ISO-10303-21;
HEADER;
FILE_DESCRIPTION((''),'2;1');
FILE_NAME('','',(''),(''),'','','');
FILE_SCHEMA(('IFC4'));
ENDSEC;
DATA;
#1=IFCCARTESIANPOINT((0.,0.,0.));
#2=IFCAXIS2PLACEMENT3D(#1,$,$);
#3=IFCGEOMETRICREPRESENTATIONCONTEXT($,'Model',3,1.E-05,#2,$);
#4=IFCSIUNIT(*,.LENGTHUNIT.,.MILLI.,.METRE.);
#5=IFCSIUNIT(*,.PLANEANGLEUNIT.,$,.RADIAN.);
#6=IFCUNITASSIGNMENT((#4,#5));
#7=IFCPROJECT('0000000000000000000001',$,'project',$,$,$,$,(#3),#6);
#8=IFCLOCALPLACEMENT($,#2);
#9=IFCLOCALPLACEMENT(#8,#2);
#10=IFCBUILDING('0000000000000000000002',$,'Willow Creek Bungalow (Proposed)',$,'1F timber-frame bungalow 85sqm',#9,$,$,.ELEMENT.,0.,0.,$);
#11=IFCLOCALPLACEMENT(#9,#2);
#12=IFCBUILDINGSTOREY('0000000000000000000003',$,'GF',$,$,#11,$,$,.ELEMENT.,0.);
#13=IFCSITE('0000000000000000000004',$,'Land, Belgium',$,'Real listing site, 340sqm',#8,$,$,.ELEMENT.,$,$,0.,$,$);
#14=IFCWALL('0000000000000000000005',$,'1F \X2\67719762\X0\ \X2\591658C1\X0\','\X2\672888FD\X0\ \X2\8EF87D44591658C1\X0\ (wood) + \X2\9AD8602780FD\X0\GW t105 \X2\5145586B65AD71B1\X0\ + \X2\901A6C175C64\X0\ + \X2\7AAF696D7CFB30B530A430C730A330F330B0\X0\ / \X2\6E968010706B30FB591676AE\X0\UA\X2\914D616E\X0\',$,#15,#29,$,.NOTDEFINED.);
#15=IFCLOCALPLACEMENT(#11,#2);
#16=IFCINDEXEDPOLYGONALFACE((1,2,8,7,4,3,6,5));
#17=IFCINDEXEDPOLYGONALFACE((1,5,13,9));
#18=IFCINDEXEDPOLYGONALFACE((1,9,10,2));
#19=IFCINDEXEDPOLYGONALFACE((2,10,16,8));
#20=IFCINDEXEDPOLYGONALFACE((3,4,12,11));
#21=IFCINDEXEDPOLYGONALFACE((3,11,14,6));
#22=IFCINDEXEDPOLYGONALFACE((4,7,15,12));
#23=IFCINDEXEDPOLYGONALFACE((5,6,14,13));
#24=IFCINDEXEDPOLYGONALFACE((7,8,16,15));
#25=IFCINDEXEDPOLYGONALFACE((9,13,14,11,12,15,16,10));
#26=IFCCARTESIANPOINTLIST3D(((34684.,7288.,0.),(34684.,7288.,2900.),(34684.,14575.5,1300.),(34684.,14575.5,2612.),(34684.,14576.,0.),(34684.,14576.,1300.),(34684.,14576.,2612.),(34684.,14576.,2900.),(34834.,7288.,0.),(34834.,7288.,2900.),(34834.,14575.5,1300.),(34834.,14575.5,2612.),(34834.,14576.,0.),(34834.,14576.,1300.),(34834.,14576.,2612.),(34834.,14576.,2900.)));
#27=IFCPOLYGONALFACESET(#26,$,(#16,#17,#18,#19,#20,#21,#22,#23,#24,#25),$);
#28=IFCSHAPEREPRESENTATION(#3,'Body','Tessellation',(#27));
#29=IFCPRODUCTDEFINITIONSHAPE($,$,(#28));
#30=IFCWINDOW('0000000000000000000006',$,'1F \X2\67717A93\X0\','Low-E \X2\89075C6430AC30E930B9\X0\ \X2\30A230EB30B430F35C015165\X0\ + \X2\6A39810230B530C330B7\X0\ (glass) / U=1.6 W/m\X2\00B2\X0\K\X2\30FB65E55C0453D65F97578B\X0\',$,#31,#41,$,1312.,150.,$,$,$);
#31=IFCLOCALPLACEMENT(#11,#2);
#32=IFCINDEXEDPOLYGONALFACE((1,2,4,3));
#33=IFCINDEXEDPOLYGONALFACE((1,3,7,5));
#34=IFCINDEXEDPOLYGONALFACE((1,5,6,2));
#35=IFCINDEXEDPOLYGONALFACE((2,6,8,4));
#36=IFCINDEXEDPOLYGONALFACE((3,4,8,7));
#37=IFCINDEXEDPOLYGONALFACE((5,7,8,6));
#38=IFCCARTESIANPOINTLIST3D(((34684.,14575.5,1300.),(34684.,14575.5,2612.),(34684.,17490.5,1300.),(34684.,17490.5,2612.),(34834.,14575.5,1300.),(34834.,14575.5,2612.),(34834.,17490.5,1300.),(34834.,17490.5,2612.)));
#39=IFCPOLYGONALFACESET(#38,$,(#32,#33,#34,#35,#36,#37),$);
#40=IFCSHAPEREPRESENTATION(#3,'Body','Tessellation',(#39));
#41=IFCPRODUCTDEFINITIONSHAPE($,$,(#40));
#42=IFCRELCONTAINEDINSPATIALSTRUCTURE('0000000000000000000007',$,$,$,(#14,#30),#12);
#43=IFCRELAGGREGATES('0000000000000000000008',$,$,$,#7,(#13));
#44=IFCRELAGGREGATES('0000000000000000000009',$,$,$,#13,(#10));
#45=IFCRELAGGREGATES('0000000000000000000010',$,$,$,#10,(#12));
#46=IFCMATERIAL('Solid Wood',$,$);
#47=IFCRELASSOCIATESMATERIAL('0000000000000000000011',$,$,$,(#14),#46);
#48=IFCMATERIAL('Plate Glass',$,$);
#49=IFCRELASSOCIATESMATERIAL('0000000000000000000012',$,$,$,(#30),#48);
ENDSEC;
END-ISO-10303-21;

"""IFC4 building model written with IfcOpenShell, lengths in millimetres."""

from ifc_helpers import new_model, si_unit, frame, frame_2d, origin, place, context, project, spatial, rectangle, extrude, material, element, fill, save


model = new_model("IFC4")

# Units and contexts
model_context = context("Model", 3, precision=1e-05, world=origin())
ifc_project = project(units=[si_unit("LENGTHUNIT", "METRE", prefix="MILLI"), si_unit("PLANEANGLEUNIT", "RADIAN")], contexts=[model_context])

# Site, building, storey
site_placement = place(None, origin())
site = spatial("IfcSite", under=ifc_project, at=site_placement, Name="Land, Belgium", ObjectType="Real listing site, 340sqm", CompositionType="ELEMENT", RefElevation=0.0)
building_placement = place(site_placement, origin())
building = spatial("IfcBuilding", under=site, at=building_placement, Name="Willow Creek Bungalow (Proposed)", ObjectType="1F timber-frame bungalow 85sqm", CompositionType="ELEMENT", ElevationOfRefHeight=0.0, ElevationOfTerrain=0.0)
storey_placement = place(building_placement, origin())
storey = spatial("IfcBuildingStorey", under=building, at=storey_placement, Name="GF", CompositionType="ELEMENT", Elevation=0.0)

# Shared definitions
ifc_material_1 = material(Name="Solid Wood")

# Wall, opening, window
wall_1_placement = place(storey_placement, frame((17342.0, 3644.0, 0.0)))
wall_1 = element("IfcWall", 1, at=wall_1_placement, inside=storey, material=ifc_material_1, Name="1F 東面 外壁", Description="木製 軸組外壁 (wood) + 高性能GW t105 充填断熱 + 通気層 + 窯業系サイディング / 準耐火・外皮UA配慮", PredefinedType="NOTDEFINED", context=model_context, shape_type="SweptSolid", body=[
    extrude(rectangle(XDim=150.0, YDim=7288.0, at=frame_2d((75.0, 3644.0))), frame((17342.0, 3644.0, 0.0)), (0.0, 0.0, 1.0), 2900.0),
])
opening_placement = place(storey_placement, frame((17342.0, 7288.0, 650.0)))
opening = element("IfcOpeningElement", 2, at=opening_placement, cuts=wall_1, PredefinedType="NOTDEFINED", context=model_context, shape_type="SweptSolid", body=[
    extrude(rectangle(XDim=150.0, YDim=2915.0, at=frame_2d((75.0, 1457.0))), frame((17342.0, 7288.0, 650.0)), (0.0, 0.0, 1.0), 1312.0),
])
ifc_material_2 = material(Name="Plate Glass")
window_placement = place(storey_placement, frame((17342.0, 7288.0, 650.0)))
window = element("IfcWindow", 3, at=window_placement, inside=storey, material=ifc_material_2, Name="1F 東窓", Description="Low-E 複層ガラス アルゴン封入 + 樹脂サッシ (glass) / U=1.6 W/m²K・日射取得型", OverallHeight=1312.0, OverallWidth=150.0, context=model_context, shape_type="SweptSolid", body=[
    extrude(rectangle(XDim=150.0, YDim=2915.0, at=frame_2d((75.0, 1457.0))), frame((17342.0, 7288.0, 650.0)), (0.0, 0.0, 1.0), 1312.0),
])
fill(opening, window)

save(model, "model.ifc")
